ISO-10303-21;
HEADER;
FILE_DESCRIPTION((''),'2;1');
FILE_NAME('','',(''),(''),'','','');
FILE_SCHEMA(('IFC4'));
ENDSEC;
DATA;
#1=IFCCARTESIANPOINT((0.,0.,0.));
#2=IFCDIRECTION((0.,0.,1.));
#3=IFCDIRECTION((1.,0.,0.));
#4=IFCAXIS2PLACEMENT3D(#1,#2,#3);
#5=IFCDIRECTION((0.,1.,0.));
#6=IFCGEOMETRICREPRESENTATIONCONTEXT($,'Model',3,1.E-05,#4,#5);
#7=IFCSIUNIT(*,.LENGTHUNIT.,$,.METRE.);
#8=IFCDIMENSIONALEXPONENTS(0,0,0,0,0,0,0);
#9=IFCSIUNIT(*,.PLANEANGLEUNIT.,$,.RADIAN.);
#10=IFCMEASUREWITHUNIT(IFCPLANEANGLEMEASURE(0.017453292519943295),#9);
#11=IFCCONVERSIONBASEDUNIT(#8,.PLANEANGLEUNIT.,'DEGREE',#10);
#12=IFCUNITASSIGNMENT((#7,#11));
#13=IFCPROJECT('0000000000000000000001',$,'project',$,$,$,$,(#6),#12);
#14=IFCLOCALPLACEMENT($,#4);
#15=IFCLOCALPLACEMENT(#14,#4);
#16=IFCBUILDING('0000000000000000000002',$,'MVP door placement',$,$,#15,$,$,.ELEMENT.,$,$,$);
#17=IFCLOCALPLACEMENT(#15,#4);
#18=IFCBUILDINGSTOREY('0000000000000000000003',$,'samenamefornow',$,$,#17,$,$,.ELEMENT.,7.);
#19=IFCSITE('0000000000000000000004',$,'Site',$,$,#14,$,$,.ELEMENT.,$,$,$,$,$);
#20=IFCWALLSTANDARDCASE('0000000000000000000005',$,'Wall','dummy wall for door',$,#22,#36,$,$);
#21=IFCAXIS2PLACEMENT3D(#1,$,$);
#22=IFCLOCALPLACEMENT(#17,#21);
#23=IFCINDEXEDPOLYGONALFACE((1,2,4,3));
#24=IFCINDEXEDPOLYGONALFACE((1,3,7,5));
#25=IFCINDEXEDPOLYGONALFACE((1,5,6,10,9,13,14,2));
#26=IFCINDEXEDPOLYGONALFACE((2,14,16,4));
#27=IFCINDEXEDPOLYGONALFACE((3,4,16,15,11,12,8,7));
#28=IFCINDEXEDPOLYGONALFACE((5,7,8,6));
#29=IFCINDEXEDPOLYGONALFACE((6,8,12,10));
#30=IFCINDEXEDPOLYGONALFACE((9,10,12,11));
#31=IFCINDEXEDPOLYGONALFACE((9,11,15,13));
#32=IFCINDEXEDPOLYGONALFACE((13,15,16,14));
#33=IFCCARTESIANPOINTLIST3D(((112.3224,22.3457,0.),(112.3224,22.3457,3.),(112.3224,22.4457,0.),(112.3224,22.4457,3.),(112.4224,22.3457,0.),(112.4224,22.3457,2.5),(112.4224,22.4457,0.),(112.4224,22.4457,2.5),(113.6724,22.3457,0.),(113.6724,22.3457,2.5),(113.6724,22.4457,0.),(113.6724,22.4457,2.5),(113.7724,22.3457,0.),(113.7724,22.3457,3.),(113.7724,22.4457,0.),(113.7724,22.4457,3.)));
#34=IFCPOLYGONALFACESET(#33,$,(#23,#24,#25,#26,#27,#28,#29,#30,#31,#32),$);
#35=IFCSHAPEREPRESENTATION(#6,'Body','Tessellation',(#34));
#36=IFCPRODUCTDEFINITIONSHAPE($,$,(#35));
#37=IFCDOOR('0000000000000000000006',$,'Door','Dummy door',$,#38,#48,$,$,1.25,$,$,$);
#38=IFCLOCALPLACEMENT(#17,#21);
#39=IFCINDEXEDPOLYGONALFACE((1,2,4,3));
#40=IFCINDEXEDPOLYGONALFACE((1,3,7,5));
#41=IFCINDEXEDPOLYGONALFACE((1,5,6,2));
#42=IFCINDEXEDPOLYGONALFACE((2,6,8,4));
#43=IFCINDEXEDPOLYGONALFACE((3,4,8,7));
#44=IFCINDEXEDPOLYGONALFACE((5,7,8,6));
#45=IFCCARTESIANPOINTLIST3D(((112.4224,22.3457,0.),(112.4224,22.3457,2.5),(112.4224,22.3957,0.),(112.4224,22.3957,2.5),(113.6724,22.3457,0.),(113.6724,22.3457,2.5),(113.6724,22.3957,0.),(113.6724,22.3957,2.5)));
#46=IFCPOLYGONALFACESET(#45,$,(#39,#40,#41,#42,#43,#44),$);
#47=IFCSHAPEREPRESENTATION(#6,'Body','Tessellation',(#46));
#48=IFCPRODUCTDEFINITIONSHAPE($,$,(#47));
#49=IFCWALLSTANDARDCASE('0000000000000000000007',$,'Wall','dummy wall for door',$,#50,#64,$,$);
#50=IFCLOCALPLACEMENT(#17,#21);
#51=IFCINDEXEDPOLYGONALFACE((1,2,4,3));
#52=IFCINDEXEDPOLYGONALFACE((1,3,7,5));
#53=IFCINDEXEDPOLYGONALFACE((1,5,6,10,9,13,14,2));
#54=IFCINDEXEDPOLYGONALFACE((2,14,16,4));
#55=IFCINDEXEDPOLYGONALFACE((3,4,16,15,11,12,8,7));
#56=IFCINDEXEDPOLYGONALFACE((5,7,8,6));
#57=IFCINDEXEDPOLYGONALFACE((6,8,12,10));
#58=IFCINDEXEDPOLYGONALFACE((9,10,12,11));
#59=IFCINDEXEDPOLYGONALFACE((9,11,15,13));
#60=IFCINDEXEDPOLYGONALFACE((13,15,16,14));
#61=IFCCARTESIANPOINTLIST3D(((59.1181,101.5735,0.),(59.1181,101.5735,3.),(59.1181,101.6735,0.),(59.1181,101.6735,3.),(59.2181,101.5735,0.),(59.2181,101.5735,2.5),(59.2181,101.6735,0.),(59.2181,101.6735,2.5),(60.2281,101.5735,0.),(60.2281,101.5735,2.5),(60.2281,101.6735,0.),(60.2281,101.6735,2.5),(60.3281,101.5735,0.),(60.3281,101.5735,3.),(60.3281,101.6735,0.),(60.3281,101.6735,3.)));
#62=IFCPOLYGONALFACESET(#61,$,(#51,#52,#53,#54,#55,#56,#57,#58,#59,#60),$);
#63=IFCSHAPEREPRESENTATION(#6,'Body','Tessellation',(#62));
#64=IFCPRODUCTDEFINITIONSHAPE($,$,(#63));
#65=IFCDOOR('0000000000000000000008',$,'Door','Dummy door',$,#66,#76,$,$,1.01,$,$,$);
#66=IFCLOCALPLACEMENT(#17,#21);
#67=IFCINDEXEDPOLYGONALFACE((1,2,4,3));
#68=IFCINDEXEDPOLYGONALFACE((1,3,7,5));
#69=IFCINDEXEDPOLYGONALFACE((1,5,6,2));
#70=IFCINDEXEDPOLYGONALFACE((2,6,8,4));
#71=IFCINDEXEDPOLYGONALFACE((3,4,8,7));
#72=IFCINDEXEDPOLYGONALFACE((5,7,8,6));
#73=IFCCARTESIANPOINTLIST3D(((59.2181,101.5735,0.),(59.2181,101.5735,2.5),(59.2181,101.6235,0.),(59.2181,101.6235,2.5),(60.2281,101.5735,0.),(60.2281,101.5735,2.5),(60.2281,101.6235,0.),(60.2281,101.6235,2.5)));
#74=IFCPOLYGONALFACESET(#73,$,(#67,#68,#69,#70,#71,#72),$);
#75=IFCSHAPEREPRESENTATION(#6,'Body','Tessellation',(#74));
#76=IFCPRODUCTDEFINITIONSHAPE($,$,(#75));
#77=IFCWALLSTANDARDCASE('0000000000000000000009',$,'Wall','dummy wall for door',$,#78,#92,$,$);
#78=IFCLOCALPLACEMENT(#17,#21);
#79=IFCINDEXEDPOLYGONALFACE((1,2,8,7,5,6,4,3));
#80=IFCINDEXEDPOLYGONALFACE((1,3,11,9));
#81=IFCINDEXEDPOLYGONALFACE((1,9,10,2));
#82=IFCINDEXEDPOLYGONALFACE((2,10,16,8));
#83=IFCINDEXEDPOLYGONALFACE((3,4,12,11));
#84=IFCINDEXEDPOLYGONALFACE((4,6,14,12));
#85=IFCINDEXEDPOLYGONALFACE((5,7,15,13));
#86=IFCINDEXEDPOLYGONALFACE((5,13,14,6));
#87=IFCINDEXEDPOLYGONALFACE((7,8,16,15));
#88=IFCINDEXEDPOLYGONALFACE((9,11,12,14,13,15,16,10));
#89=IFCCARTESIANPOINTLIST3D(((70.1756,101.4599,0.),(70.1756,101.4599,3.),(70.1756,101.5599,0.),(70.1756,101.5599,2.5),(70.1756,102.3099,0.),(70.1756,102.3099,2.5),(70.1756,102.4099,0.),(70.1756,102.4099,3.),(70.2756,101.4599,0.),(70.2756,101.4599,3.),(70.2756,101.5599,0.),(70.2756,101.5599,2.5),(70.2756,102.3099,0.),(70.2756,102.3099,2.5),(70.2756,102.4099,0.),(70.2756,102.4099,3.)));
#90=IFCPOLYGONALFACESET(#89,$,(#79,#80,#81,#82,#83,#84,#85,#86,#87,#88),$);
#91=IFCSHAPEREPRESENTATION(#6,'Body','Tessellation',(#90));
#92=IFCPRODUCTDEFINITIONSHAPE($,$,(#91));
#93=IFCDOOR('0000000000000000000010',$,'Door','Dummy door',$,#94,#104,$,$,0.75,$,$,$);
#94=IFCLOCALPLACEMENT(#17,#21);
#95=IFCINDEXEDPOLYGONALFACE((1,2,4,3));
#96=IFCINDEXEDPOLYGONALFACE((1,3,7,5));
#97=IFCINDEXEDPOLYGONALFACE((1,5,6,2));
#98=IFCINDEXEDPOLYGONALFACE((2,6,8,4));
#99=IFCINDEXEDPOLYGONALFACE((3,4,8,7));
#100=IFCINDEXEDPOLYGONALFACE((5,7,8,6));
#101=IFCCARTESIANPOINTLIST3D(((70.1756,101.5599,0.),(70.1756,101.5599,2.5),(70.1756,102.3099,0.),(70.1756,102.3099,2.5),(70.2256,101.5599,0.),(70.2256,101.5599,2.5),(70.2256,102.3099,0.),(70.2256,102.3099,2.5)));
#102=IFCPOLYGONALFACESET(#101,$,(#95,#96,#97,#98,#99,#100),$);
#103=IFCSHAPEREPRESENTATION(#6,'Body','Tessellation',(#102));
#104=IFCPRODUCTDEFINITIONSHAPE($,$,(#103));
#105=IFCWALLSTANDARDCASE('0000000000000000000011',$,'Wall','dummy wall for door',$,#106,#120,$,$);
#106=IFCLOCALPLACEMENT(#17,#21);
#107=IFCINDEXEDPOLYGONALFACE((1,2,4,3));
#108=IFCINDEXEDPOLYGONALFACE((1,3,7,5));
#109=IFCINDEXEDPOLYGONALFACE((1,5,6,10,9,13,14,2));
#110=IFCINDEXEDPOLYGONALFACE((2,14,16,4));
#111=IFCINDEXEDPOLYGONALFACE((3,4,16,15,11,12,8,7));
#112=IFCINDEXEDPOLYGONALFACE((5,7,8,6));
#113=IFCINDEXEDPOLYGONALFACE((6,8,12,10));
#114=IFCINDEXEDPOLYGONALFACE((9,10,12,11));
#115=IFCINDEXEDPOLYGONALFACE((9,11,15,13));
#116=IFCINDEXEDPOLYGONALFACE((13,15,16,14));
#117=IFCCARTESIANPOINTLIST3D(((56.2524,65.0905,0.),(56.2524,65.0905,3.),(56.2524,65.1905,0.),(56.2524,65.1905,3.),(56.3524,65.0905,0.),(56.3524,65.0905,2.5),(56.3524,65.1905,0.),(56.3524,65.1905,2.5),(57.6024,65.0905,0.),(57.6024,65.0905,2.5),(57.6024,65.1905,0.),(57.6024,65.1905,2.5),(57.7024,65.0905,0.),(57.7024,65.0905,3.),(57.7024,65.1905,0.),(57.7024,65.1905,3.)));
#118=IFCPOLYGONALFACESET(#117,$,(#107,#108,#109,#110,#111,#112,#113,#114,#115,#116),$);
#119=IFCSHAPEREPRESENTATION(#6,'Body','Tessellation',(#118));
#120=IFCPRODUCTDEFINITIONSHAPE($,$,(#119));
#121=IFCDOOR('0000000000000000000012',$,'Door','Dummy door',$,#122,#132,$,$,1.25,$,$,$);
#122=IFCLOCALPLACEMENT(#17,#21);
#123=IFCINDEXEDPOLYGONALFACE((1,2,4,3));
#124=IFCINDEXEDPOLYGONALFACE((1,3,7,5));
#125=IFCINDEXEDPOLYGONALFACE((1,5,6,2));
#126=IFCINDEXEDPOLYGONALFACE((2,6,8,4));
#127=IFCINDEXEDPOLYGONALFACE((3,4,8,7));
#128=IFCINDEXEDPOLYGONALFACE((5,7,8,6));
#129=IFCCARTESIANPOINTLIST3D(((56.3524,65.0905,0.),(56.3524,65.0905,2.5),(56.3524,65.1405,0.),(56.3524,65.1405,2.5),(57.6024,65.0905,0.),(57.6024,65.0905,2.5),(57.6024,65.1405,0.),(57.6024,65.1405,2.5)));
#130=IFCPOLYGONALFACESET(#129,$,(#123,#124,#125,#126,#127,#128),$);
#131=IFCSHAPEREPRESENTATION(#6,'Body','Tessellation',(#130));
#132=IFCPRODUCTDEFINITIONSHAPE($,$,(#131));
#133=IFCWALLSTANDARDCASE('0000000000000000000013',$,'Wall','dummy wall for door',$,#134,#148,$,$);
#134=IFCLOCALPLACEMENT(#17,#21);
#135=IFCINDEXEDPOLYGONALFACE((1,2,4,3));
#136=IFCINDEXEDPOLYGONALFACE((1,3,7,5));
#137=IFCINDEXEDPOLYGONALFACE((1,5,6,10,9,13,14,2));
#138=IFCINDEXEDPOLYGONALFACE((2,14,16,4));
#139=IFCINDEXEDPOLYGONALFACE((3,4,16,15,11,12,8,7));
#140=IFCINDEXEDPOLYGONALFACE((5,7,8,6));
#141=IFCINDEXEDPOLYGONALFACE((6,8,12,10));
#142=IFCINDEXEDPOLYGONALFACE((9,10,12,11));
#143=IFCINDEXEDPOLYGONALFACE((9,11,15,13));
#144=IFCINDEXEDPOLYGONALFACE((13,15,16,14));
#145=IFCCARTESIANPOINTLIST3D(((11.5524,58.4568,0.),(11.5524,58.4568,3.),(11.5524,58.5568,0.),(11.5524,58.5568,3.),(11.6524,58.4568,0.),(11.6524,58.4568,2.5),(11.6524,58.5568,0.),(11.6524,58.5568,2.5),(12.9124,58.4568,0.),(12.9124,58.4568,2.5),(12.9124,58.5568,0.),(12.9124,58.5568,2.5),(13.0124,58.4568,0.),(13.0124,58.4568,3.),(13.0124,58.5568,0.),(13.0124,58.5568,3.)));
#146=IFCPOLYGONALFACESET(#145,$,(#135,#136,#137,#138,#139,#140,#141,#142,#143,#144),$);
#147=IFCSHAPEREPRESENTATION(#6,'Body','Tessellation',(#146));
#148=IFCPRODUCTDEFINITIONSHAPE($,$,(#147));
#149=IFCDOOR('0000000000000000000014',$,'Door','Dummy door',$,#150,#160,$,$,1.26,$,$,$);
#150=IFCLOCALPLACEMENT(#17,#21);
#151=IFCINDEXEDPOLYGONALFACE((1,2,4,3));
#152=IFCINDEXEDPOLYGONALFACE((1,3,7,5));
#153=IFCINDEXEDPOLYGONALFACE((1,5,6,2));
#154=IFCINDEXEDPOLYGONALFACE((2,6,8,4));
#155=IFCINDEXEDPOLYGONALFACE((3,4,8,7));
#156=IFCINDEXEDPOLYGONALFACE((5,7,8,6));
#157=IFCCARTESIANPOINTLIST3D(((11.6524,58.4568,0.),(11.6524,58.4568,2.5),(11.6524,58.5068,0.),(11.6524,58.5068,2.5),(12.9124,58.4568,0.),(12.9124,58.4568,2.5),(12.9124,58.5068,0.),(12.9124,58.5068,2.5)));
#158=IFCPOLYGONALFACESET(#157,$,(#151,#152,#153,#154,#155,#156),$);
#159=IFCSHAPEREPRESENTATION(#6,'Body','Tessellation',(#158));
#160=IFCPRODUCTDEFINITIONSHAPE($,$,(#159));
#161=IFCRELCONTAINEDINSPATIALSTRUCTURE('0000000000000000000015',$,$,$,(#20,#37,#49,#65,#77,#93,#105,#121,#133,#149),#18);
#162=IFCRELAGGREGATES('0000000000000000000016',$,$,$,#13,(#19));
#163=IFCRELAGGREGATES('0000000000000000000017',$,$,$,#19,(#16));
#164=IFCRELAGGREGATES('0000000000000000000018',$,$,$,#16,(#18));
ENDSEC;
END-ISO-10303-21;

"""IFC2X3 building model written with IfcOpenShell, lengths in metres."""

from ifc_helpers import new_model, entity, si_unit, converted_unit, direction, origin_with_axes, place, context, project, spatial, polyline, outline, extrude, element, fill, save


model = new_model("IFC2X3")

# Units and contexts
model_context = context("Model", 3, precision=1e-05, world=origin_with_axes(), true_north=direction((0.0, 1.0, 0.0)))
ifc_project = project(units=[si_unit("LENGTHUNIT", "METRE"), converted_unit("PLANEANGLEUNIT", "DEGREE", entity("IfcPlaneAngleMeasure", 0.017453292519943295), si_unit("PLANEANGLEUNIT", "RADIAN"), dimensions=[0, 0, 0, 0, 0, 0, 0])], contexts=[model_context])

# Site, building, storey
site_placement = place(None, origin_with_axes())
site = spatial("IfcSite", under=ifc_project, at=site_placement, Name="Site", CompositionType="ELEMENT")
building_placement = place(site_placement, origin_with_axes())
building = spatial("IfcBuilding", under=site, at=building_placement, Name="MVP door placement", CompositionType="ELEMENT")
storey_placement = place(building_placement, origin_with_axes())
storey = spatial("IfcBuildingStorey", under=building, at=storey_placement, Name="samenamefornow", CompositionType="ELEMENT", Elevation=7.0)

# Walls, openings, doors
wall_1_placement = place(storey_placement, origin_with_axes())
wall_1 = element("IfcWallStandardCase", 1, at=wall_1_placement, inside=storey, Name="Wall", Description="dummy wall for door", context=model_context, shape_type="SweptSolid", body=[
    extrude(outline(polyline([(113.7724, 22.3457, 0.0), (112.3224, 22.3457, 0.0), (112.3224, 22.4457, 0.0), (113.7724, 22.4457, 0.0), (113.7724, 22.3457, 0.0)])), origin_with_axes(), (0.0, 0.0, 1.0), 3.0),
])
opening_1_placement = place(wall_1_placement, origin_with_axes())
opening_1 = element("IfcOpeningElement", 2, at=opening_1_placement, cuts=wall_1, context=model_context, shape_type="SweptSolid", body=[
    extrude(outline(polyline([(113.6724, 22.3457, 0.0), (112.4224, 22.3457, 0.0), (112.4224, 22.4457, 0.0), (113.6724, 22.4457, 0.0), (113.6724, 22.3457, 0.0)])), origin_with_axes(), (0.0, 0.0, 1.0), 2.5),
])
door_1_placement = place(opening_1_placement, origin_with_axes())
door_1 = element("IfcDoor", 3, at=door_1_placement, inside=storey, Name="Door", Description="Dummy door", OverallWidth=1.25, context=model_context, shape_type="SweptSolid", body=[
    extrude(outline(polyline([(113.6724, 22.3457, 0.0), (112.4224, 22.3457, 0.0), (112.4224, 22.3957, 0.0), (113.6724, 22.3957, 0.0), (113.6724, 22.3457, 0.0)])), origin_with_axes(), (0.0, 0.0, 1.0), 2.5),
])
fill(opening_1, door_1)
wall_2_placement = place(storey_placement, origin_with_axes())
wall_2 = element("IfcWallStandardCase", 4, at=wall_2_placement, inside=storey, Name="Wall", Description="dummy wall for door", context=model_context, shape_type="SweptSolid", body=[
    extrude(outline(polyline([(60.3281, 101.5735, 0.0), (59.1181, 101.5735, 0.0), (59.1181, 101.6735, 0.0), (60.3281, 101.6735, 0.0), (60.3281, 101.5735, 0.0)])), origin_with_axes(), (0.0, 0.0, 1.0), 3.0),
])
opening_2_placement = place(wall_2_placement, origin_with_axes())
opening_2 = element("IfcOpeningElement", 5, at=opening_2_placement, cuts=wall_2, context=model_context, shape_type="SweptSolid", body=[
    extrude(outline(polyline([(60.2281, 101.5735, 0.0), (59.2181, 101.5735, 0.0), (59.2181, 101.6735, 0.0), (60.2281, 101.6735, 0.0), (60.2281, 101.5735, 0.0)])), origin_with_axes(), (0.0, 0.0, 1.0), 2.5),
])
door_2_placement = place(opening_2_placement, origin_with_axes())
door_2 = element("IfcDoor", 6, at=door_2_placement, inside=storey, Name="Door", Description="Dummy door", OverallWidth=1.01, context=model_context, shape_type="SweptSolid", body=[
    extrude(outline(polyline([(60.2281, 101.5735, 0.0), (59.2181, 101.5735, 0.0), (59.2181, 101.6235, 0.0), (60.2281, 101.6235, 0.0), (60.2281, 101.5735, 0.0)])), origin_with_axes(), (0.0, 0.0, 1.0), 2.5),
])
fill(opening_2, door_2)
wall_3_placement = place(storey_placement, origin_with_axes())
wall_3 = element("IfcWallStandardCase", 7, at=wall_3_placement, inside=storey, Name="Wall", Description="dummy wall for door", context=model_context, shape_type="SweptSolid", body=[
    extrude(outline(polyline([(70.1756, 101.4599, 0.0), (70.1756, 102.4099, 0.0), (70.2756, 102.4099, 0.0), (70.2756, 101.4599, 0.0), (70.1756, 101.4599, 0.0)])), origin_with_axes(), (0.0, 0.0, 1.0), 3.0),
])
opening_3_placement = place(wall_3_placement, origin_with_axes())
opening_3 = element("IfcOpeningElement", 8, at=opening_3_placement, cuts=wall_3, context=model_context, shape_type="SweptSolid", body=[
    extrude(outline(polyline([(70.1756, 101.5599, 0.0), (70.1756, 102.3099, 0.0), (70.2756, 102.3099, 0.0), (70.2756, 101.5599, 0.0), (70.1756, 101.5599, 0.0)])), origin_with_axes(), (0.0, 0.0, 1.0), 2.5),
])
door_3_placement = place(opening_3_placement, origin_with_axes())
door_3 = element("IfcDoor", 9, at=door_3_placement, inside=storey, Name="Door", Description="Dummy door", OverallWidth=0.75, context=model_context, shape_type="SweptSolid", body=[
    extrude(outline(polyline([(70.1756, 101.5599, 0.0), (70.1756, 102.3099, 0.0), (70.2256, 102.3099, 0.0), (70.2256, 101.5599, 0.0), (70.1756, 101.5599, 0.0)])), origin_with_axes(), (0.0, 0.0, 1.0), 2.5),
])
fill(opening_3, door_3)
wall_4_placement = place(storey_placement, origin_with_axes())
wall_4 = element("IfcWallStandardCase", 10, at=wall_4_placement, inside=storey, Name="Wall", Description="dummy wall for door", context=model_context, shape_type="SweptSolid", body=[
    extrude(outline(polyline([(56.2524, 65.0905, 0.0), (57.7024, 65.0905, 0.0), (57.7024, 65.1905, 0.0), (56.2524, 65.1905, 0.0), (56.2524, 65.0905, 0.0)])), origin_with_axes(), (0.0, 0.0, 1.0), 3.0),
])
opening_4_placement = place(wall_4_placement, origin_with_axes())
opening_4 = element("IfcOpeningElement", 11, at=opening_4_placement, cuts=wall_4, context=model_context, shape_type="SweptSolid", body=[
    extrude(outline(polyline([(56.3524, 65.0905, 0.0), (57.6024, 65.0905, 0.0), (57.6024, 65.1905, 0.0), (56.3524, 65.1905, 0.0), (56.3524, 65.0905, 0.0)])), origin_with_axes(), (0.0, 0.0, 1.0), 2.5),
])
door_4_placement = place(opening_4_placement, origin_with_axes())
door_4 = element("IfcDoor", 12, at=door_4_placement, inside=storey, Name="Door", Description="Dummy door", OverallWidth=1.25, context=model_context, shape_type="SweptSolid", body=[
    extrude(outline(polyline([(56.3524, 65.0905, 0.0), (57.6024, 65.0905, 0.0), (57.6024, 65.1405, 0.0), (56.3524, 65.1405, 0.0), (56.3524, 65.0905, 0.0)])), origin_with_axes(), (0.0, 0.0, 1.0), 2.5),
])
fill(opening_4, door_4)
wall_5_placement = place(storey_placement, origin_with_axes())
wall_5 = element("IfcWallStandardCase", 13, at=wall_5_placement, inside=storey, Name="Wall", Description="dummy wall for door", context=model_context, shape_type="SweptSolid", body=[
    extrude(outline(polyline([(11.5524, 58.4568, 0.0), (13.0124, 58.4568, 0.0), (13.0124, 58.5568, 0.0), (11.5524, 58.5568, 0.0), (11.5524, 58.4568, 0.0)])), origin_with_axes(), (0.0, 0.0, 1.0), 3.0),
])
opening_5_placement = place(wall_5_placement, origin_with_axes())
opening_5 = element("IfcOpeningElement", 14, at=opening_5_placement, cuts=wall_5, context=model_context, shape_type="SweptSolid", body=[
    extrude(outline(polyline([(11.6524, 58.4568, 0.0), (12.9124, 58.4568, 0.0), (12.9124, 58.5568, 0.0), (11.6524, 58.5568, 0.0), (11.6524, 58.4568, 0.0)])), origin_with_axes(), (0.0, 0.0, 1.0), 2.5),
])
door_5_placement = place(opening_5_placement, origin_with_axes())
door_5 = element("IfcDoor", 15, at=door_5_placement, inside=storey, Name="Door", Description="Dummy door", OverallWidth=1.26, context=model_context, shape_type="SweptSolid", body=[
    extrude(outline(polyline([(11.6524, 58.4568, 0.0), (12.9124, 58.4568, 0.0), (12.9124, 58.5068, 0.0), (11.6524, 58.5068, 0.0), (11.6524, 58.4568, 0.0)])), origin_with_axes(), (0.0, 0.0, 1.0), 2.5),
])
fill(opening_5, door_5)

save(model, "model.ifc")
